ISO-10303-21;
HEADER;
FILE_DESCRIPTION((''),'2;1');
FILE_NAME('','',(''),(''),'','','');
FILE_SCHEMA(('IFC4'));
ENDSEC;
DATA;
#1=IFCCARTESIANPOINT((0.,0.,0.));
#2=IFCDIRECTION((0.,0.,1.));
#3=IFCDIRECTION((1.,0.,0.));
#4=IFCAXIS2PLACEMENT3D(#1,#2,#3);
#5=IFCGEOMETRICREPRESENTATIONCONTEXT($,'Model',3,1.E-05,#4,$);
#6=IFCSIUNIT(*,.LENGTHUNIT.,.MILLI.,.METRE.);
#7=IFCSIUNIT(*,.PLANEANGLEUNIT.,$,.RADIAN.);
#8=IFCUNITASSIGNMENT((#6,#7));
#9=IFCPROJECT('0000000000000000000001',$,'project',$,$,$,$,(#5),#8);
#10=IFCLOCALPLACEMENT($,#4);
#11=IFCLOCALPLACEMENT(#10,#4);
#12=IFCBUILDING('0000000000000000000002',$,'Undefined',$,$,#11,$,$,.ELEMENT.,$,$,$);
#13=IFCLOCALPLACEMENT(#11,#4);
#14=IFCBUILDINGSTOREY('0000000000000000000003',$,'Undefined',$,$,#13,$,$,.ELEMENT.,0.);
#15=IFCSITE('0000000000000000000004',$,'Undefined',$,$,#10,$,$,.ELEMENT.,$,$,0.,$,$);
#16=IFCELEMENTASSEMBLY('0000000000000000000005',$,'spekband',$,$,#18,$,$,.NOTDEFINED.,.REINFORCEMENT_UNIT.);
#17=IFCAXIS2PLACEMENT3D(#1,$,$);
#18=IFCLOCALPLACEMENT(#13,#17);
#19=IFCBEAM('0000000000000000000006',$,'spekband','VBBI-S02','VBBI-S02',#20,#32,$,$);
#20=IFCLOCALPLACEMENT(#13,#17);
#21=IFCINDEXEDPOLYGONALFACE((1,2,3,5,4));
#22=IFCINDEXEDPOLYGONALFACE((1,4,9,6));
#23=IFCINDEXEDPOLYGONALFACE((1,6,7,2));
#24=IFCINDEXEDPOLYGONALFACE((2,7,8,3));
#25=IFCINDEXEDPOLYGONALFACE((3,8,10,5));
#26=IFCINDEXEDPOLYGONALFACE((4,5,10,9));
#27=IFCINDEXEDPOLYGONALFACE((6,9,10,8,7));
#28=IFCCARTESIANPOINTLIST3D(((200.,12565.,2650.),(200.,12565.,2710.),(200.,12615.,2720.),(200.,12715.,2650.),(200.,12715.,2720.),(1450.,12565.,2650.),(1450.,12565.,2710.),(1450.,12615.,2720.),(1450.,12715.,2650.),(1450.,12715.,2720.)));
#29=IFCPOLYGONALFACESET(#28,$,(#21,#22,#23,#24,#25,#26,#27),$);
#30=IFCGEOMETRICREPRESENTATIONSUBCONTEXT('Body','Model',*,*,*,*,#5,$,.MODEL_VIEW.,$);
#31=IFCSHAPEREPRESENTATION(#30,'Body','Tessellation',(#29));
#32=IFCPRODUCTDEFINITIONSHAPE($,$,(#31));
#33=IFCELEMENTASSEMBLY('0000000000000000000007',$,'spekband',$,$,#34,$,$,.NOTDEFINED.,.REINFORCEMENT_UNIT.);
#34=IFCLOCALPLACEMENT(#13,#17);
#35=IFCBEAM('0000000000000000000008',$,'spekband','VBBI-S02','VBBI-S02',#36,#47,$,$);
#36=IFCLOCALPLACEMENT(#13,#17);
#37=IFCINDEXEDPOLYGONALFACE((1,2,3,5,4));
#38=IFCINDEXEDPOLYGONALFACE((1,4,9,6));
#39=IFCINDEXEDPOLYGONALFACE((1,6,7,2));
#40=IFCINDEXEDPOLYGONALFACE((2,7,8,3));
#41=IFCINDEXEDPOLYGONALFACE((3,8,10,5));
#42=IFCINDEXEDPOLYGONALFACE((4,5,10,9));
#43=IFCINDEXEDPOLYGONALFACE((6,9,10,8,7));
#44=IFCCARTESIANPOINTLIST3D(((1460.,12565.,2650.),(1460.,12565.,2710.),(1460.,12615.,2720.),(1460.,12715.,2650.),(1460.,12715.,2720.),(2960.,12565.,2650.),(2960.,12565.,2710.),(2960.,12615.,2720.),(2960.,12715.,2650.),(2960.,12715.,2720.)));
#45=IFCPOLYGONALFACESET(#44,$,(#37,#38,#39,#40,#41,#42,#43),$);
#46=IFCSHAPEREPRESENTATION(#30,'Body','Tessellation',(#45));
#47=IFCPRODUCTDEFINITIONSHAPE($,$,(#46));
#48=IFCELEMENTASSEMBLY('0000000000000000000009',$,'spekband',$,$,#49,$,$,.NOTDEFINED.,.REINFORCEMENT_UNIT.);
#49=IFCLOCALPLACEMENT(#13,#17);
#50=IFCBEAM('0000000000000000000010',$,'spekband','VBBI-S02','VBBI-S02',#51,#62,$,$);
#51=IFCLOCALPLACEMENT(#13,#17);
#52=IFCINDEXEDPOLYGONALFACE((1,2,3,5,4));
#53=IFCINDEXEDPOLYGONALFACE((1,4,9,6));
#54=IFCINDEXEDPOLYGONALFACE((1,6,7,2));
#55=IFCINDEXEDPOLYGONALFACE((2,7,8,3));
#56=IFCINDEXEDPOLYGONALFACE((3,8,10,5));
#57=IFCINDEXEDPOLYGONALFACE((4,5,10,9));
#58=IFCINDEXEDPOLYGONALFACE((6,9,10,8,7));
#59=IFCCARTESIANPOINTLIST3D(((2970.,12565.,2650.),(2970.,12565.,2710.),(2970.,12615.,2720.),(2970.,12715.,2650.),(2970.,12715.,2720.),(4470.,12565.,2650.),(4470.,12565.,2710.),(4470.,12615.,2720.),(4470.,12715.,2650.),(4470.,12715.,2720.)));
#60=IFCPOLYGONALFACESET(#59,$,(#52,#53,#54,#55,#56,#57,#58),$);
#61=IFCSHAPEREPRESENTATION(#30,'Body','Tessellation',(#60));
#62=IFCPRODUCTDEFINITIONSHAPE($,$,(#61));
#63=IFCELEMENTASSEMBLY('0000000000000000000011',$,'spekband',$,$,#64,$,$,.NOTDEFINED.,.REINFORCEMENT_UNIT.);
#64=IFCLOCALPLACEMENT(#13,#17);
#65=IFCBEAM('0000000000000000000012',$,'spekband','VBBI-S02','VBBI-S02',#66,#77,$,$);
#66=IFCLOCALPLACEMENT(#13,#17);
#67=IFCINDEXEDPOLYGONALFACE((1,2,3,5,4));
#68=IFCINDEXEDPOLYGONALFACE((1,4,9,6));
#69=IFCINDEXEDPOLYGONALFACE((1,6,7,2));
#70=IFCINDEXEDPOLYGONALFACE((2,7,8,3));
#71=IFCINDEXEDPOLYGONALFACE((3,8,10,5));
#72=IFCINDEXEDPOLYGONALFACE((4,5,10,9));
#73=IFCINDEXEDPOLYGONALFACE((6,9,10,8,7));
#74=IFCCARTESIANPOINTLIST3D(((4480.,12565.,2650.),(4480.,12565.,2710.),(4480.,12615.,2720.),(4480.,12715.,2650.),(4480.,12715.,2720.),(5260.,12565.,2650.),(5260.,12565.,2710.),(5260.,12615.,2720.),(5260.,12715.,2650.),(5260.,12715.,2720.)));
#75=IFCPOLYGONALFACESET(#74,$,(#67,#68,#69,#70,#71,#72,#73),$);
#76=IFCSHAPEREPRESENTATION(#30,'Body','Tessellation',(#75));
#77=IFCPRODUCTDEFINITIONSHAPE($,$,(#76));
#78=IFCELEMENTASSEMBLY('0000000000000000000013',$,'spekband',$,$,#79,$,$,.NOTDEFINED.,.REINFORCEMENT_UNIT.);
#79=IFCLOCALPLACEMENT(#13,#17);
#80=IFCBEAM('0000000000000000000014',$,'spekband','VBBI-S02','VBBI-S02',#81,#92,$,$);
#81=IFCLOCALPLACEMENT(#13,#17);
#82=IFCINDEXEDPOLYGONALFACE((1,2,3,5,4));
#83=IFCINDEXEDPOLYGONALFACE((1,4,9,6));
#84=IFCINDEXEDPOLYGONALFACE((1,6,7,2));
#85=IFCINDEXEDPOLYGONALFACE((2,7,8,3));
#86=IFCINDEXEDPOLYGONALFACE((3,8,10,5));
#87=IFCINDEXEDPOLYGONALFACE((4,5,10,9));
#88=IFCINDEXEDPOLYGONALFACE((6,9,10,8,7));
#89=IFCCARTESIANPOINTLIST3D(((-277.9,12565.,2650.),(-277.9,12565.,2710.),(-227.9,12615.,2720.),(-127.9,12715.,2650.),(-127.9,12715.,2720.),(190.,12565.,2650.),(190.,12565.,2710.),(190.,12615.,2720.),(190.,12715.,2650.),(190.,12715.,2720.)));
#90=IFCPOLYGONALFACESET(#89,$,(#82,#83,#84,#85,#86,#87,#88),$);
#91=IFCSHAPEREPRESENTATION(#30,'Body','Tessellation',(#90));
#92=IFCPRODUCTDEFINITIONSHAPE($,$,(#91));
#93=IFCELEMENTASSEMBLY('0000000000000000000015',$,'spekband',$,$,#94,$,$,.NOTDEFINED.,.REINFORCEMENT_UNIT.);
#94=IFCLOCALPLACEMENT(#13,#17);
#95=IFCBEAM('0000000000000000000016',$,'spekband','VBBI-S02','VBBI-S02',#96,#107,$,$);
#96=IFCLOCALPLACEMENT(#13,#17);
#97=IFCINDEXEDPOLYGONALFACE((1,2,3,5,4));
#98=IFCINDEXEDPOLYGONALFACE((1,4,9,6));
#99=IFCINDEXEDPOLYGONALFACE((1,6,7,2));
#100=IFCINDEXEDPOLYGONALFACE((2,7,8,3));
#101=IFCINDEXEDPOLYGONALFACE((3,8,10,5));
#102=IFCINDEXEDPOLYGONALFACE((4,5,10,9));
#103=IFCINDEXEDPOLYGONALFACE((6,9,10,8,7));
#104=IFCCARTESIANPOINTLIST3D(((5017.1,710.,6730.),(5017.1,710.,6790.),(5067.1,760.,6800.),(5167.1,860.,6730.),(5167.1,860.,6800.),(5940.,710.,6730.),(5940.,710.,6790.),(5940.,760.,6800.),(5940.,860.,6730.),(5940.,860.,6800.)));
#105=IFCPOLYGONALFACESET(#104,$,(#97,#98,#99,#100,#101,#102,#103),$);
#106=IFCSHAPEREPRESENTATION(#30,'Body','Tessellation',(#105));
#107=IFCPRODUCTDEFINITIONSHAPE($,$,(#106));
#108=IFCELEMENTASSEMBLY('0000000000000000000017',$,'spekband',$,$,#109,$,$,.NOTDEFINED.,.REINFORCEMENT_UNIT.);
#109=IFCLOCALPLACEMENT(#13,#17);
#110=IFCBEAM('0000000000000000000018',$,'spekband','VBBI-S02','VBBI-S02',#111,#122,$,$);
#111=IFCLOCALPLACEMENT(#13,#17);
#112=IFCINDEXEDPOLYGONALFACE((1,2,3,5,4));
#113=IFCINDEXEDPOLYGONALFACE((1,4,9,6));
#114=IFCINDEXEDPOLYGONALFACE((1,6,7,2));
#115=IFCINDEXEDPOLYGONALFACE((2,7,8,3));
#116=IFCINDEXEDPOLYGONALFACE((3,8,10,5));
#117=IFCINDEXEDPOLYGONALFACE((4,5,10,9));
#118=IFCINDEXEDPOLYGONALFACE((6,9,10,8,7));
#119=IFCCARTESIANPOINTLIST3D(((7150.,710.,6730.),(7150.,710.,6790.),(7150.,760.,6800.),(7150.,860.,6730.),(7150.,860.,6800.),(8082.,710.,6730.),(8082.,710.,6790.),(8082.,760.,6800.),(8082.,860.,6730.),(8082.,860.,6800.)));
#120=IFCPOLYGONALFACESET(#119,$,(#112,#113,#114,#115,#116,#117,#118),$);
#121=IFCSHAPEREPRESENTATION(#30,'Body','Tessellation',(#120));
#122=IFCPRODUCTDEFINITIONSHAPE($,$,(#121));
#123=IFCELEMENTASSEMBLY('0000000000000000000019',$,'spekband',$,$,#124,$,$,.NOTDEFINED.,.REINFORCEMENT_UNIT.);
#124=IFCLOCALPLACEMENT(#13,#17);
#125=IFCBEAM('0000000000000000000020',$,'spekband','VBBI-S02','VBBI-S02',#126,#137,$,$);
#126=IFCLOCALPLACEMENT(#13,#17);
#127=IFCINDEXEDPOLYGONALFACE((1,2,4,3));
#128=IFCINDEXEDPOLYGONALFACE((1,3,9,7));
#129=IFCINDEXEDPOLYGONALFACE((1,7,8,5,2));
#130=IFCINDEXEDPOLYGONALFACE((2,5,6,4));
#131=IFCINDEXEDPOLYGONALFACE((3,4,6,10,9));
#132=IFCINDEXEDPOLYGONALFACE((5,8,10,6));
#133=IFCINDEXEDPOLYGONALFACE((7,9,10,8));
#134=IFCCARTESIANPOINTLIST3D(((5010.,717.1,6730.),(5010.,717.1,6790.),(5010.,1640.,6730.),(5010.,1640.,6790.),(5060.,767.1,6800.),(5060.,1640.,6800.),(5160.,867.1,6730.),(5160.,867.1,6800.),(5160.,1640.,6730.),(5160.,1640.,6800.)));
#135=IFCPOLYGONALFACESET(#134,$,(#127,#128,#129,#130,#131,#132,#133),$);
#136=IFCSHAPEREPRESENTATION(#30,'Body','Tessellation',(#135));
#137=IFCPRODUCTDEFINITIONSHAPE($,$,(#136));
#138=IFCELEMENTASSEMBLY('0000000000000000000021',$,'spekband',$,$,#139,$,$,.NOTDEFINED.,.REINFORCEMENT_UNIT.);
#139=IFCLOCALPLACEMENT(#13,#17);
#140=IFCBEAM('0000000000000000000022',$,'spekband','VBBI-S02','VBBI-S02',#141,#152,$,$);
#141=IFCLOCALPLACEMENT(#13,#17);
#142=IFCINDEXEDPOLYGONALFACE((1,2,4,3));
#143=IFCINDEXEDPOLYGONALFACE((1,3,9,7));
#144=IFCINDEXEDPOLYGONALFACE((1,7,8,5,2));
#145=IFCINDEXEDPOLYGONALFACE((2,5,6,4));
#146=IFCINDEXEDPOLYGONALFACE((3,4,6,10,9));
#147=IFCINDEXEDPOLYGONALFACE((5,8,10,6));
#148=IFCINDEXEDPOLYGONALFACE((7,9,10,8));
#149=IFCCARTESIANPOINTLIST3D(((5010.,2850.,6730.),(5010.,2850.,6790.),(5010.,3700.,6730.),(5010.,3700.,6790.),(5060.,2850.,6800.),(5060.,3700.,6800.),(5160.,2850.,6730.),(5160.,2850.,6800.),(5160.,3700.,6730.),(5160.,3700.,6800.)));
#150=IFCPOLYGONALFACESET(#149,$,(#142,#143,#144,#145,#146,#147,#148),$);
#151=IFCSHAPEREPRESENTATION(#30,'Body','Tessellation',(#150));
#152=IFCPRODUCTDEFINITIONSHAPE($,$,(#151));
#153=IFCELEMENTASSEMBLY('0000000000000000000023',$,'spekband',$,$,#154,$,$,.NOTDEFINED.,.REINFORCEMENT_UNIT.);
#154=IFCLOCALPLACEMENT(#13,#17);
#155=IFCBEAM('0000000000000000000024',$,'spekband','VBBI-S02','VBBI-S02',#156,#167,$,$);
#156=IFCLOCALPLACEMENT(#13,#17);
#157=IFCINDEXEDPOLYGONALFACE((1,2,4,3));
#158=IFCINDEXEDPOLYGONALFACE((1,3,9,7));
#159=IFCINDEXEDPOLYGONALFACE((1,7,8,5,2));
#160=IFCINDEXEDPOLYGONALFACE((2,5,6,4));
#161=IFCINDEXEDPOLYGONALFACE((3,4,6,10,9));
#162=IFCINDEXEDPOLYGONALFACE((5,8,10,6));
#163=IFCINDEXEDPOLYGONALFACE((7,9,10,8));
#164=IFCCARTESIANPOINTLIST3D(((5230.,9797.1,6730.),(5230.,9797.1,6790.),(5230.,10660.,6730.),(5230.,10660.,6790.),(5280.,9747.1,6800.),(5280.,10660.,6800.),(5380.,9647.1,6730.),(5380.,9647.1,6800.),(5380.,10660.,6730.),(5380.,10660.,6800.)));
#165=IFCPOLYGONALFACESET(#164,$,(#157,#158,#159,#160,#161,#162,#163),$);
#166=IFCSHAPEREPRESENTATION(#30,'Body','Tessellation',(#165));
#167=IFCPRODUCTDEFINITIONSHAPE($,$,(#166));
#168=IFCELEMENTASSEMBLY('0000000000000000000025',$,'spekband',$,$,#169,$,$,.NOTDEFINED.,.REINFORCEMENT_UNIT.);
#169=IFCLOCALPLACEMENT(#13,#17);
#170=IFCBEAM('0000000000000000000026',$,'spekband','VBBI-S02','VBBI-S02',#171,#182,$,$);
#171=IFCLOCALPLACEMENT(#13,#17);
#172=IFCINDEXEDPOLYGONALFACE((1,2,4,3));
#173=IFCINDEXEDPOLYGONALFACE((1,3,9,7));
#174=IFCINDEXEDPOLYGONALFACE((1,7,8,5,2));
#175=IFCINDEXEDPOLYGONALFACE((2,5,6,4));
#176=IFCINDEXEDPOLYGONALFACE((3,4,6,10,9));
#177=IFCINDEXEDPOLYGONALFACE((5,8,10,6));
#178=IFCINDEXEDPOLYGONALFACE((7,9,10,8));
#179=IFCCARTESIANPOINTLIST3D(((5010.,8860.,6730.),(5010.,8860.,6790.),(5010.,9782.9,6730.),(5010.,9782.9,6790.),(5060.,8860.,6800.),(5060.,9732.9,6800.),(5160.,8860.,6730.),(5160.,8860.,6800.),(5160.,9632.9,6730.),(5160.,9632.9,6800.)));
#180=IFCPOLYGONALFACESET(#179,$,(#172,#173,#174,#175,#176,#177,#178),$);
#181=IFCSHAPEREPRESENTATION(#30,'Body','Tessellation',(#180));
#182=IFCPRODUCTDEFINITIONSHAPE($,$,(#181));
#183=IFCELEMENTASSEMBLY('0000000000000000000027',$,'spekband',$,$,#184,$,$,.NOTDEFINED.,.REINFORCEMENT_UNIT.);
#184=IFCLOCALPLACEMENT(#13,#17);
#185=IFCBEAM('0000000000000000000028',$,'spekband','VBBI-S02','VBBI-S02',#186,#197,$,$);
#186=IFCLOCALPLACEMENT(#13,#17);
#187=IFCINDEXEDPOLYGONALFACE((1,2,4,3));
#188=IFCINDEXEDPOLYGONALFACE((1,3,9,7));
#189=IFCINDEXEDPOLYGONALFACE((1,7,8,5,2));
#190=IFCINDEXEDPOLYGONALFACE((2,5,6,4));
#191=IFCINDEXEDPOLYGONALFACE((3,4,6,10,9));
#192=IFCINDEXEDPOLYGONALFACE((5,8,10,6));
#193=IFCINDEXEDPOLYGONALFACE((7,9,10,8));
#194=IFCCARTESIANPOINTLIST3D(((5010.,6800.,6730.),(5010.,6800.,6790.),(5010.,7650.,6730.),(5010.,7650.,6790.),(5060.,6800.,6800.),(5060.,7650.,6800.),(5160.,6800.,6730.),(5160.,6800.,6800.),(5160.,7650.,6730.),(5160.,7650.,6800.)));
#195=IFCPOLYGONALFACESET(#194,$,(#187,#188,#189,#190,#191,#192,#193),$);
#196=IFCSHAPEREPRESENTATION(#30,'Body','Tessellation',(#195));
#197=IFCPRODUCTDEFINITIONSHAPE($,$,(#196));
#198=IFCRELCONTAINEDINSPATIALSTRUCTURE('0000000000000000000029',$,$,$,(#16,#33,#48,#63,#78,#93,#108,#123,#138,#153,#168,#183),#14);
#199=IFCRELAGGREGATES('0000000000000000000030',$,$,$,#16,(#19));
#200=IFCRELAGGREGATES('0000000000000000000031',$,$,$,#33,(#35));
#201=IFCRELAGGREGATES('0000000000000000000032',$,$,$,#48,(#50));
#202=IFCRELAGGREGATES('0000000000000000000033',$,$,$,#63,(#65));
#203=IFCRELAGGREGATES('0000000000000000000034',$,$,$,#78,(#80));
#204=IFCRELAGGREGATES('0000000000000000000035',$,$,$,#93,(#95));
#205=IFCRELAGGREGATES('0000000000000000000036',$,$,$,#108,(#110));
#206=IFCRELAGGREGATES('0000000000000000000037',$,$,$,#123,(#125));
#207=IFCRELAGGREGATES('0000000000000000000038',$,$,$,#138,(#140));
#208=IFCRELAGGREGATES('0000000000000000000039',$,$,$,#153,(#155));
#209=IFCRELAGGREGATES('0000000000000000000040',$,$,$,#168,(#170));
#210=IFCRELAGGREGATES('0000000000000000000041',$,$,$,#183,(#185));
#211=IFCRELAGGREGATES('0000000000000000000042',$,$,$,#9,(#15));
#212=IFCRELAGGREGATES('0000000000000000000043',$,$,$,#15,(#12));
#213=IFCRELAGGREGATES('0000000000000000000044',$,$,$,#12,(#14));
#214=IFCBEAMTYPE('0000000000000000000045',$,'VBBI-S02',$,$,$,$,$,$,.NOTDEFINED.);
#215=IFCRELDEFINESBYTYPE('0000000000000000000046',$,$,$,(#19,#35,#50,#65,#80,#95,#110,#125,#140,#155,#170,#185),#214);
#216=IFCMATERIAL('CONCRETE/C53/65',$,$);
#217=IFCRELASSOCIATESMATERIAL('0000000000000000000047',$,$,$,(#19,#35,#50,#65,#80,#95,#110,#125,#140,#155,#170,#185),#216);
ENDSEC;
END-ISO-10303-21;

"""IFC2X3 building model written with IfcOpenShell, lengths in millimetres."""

from ifc_helpers import new_model, si_unit, frame, origin_with_axes, place, context, subcontext, project, spatial, polyline, outline, extrude, clip, halfspace, material, type_object, element, aggregate, save


model = new_model("IFC2X3")

# Units and contexts
model_context = context("Model", 3, precision=1e-05, world=origin_with_axes())
body_context = subcontext(model_context, "Body", "Model", "MODEL_VIEW")
ifc_project = project(units=[si_unit("LENGTHUNIT", "METRE", prefix="MILLI"), si_unit("PLANEANGLEUNIT", "RADIAN")], contexts=[model_context])

# Site, building, storey
site_placement = place(None, origin_with_axes())
site = spatial("IfcSite", under=ifc_project, at=site_placement, Name="Undefined", CompositionType="ELEMENT", RefElevation=0.0)
building_placement = place(site_placement, origin_with_axes())
building = spatial("IfcBuilding", under=site, at=building_placement, Name="Undefined", CompositionType="ELEMENT")
storey_placement = place(building_placement, origin_with_axes())
storey = spatial("IfcBuildingStorey", under=building, at=storey_placement, Name="Undefined", CompositionType="ELEMENT", Elevation=0.0)

# Element assemblies, beams
assembly_1_placement = place(storey_placement, origin_with_axes())
assembly_1 = element("IfcElementAssembly", 1, at=assembly_1_placement, inside=storey, Name="spekband", AssemblyPlace="NOTDEFINED", PredefinedType="REINFORCEMENT_UNIT")
ifc_material = material(Name="CONCRETE/C53/65")
beam_type_1 = type_object("IfcBeamType", Name="VBBI-S02", PredefinedType="NOTDEFINED")
beam_1_placement = place(assembly_1_placement, frame((200.0, 12640.0, 2685.0), z_axis=(0.0, -1.0, 0.0), x_axis=(1.0, 0.0, 0.0)))
beam_1 = element("IfcBeam", 2, at=beam_1_placement, type_object=beam_type_1, material=ifc_material, Name="spekband", Description="VBBI-S02", ObjectType="VBBI-S02", context=body_context, shape_type="SweptSolid", body=[
    extrude(outline(polyline([(35.0, -75.0), (-35.0, -75.0), (-35.0, 25.0), (-25.0, 75.0), (35.0, 75.0), (35.0, -75.0)])), frame((1250.0, 0.0, 0.0), z_axis=(-1.0, 0.0, 0.0), x_axis=(0.0, -1.0, 0.0)), (0.0, 0.0, 1.0), 1250.0),
])
aggregate(assembly_1, [beam_1])
assembly_2_placement = place(storey_placement, origin_with_axes())
assembly_2 = element("IfcElementAssembly", 3, at=assembly_2_placement, inside=storey, Name="spekband", AssemblyPlace="NOTDEFINED", PredefinedType="REINFORCEMENT_UNIT")
beam_2_placement = place(assembly_2_placement, frame((1460.0, 12640.0, 2685.0), z_axis=(0.0, -1.0, 0.0), x_axis=(1.0, 0.0, 0.0)))
beam_2 = element("IfcBeam", 4, at=beam_2_placement, type_object=beam_type_1, material=ifc_material, Name="spekband", Description="VBBI-S02", ObjectType="VBBI-S02", context=body_context, shape_type="SweptSolid", body=[
    extrude(outline(polyline([(35.0, -75.0), (-35.0, -75.0), (-35.0, 25.0), (-25.0, 75.0), (35.0, 75.0), (35.0, -75.0)])), frame((1500.0, 0.0, 0.0), z_axis=(-1.0, 0.0, 0.0), x_axis=(0.0, -1.0, 0.0)), (0.0, 0.0, 1.0), 1500.0),
])
aggregate(assembly_2, [beam_2])
assembly_3_placement = place(storey_placement, origin_with_axes())
assembly_3 = element("IfcElementAssembly", 5, at=assembly_3_placement, inside=storey, Name="spekband", AssemblyPlace="NOTDEFINED", PredefinedType="REINFORCEMENT_UNIT")
beam_3_placement = place(assembly_3_placement, frame((2970.0, 12640.0, 2685.0), z_axis=(0.0, -1.0, 0.0), x_axis=(1.0, 0.0, 0.0)))
beam_3 = element("IfcBeam", 6, at=beam_3_placement, type_object=beam_type_1, material=ifc_material, Name="spekband", Description="VBBI-S02", ObjectType="VBBI-S02", context=body_context, shape_type="SweptSolid", body=[
    extrude(outline(polyline([(35.0, -75.0), (-35.0, -75.0), (-35.0, 25.0), (-25.0, 75.0), (35.0, 75.0), (35.0, -75.0)])), frame((1500.0, 0.0, 0.0), z_axis=(-1.0, 0.0, 0.0), x_axis=(0.0, -1.0, 0.0)), (0.0, 0.0, 1.0), 1500.0),
])
aggregate(assembly_3, [beam_3])
assembly_4_placement = place(storey_placement, origin_with_axes())
assembly_4 = element("IfcElementAssembly", 7, at=assembly_4_placement, inside=storey, Name="spekband", AssemblyPlace="NOTDEFINED", PredefinedType="REINFORCEMENT_UNIT")
beam_4_placement = place(assembly_4_placement, frame((4480.0, 12640.0, 2685.0), z_axis=(0.0, -1.0, 0.0), x_axis=(1.0, 0.0, 0.0)))
beam_4 = element("IfcBeam", 8, at=beam_4_placement, type_object=beam_type_1, material=ifc_material, Name="spekband", Description="VBBI-S02", ObjectType="VBBI-S02", context=body_context, shape_type="SweptSolid", body=[
    extrude(outline(polyline([(35.0, -75.0), (-35.0, -75.0), (-35.0, 25.0), (-25.0, 75.0), (35.0, 75.0), (35.0, -75.0)])), frame((780.0, 0.0, 0.0), z_axis=(-1.0, 0.0, 0.0), x_axis=(0.0, -1.0, 0.0)), (0.0, 0.0, 1.0), 780.0),
])
aggregate(assembly_4, [beam_4])
assembly_5_placement = place(storey_placement, origin_with_axes())
assembly_5 = element("IfcElementAssembly", 9, at=assembly_5_placement, inside=storey, Name="spekband", AssemblyPlace="NOTDEFINED", PredefinedType="REINFORCEMENT_UNIT")
beam_5_placement = place(assembly_5_placement, frame((-285.0, 12640.0, 2685.0), z_axis=(0.0, -1.0, 0.0), x_axis=(1.0, 0.0, 0.0)))
beam_5 = element("IfcBeam", 10, at=beam_5_placement, type_object=beam_type_1, material=ifc_material, Name="spekband", Description="VBBI-S02", ObjectType="VBBI-S02", context=body_context, shape_type="Clipping", body=[
    clip(extrude(outline(polyline([(35.0, -75.0), (-35.0, -75.0), (-35.0, 25.0), (-25.0, 75.0), (35.0, 75.0), (35.0, -75.0)])), frame((475.0, 0.0, 0.0), z_axis=(-1.0, 0.0, 0.0), x_axis=(0.0, -1.0, 0.0)), (0.0, 0.0, 1.0), 468.7), halfspace(frame((3.5, 0.0, 78.5), z_axis=(0.707107, 0.0, 0.707107), x_axis=(0.0, 1.0, 0.0)), True)),
])
aggregate(assembly_5, [beam_5])
assembly_6_placement = place(storey_placement, origin_with_axes())
assembly_6 = element("IfcElementAssembly", 11, at=assembly_6_placement, inside=storey, Name="spekband", AssemblyPlace="NOTDEFINED", PredefinedType="REINFORCEMENT_UNIT")
beam_6_placement = place(assembly_6_placement, frame((5010.0, 785.0, 6765.0), z_axis=(0.0, -1.0, 0.0), x_axis=(1.0, 0.0, 0.0)))
beam_6 = element("IfcBeam", 12, at=beam_6_placement, type_object=beam_type_1, material=ifc_material, Name="spekband", Description="VBBI-S02", ObjectType="VBBI-S02", context=body_context, shape_type="Clipping", body=[
    clip(extrude(outline(polyline([(35.0, -75.0), (-35.0, -75.0), (-35.0, 25.0), (-25.0, 75.0), (35.0, 75.0), (35.0, -75.0)])), frame((930.0, 0.0, 0.0), z_axis=(-1.0, 0.0, 0.0), x_axis=(0.0, -1.0, 0.0)), (0.0, 0.0, 1.0), 923.7), halfspace(frame((3.5, 0.0, 78.5), z_axis=(0.707107, 0.0, 0.707107), x_axis=(0.0, 1.0, 0.0)), True)),
])
aggregate(assembly_6, [beam_6])
assembly_7_placement = place(storey_placement, origin_with_axes())
assembly_7 = element("IfcElementAssembly", 13, at=assembly_7_placement, inside=storey, Name="spekband", AssemblyPlace="NOTDEFINED", PredefinedType="REINFORCEMENT_UNIT")
beam_7_placement = place(assembly_7_placement, frame((7150.0, 785.0, 6765.0), z_axis=(0.0, -1.0, 0.0), x_axis=(1.0, 0.0, 0.0)))
beam_7 = element("IfcBeam", 14, at=beam_7_placement, type_object=beam_type_1, material=ifc_material, Name="spekband", Description="VBBI-S02", ObjectType="VBBI-S02", context=body_context, shape_type="SweptSolid", body=[
    extrude(outline(polyline([(35.0, -75.0), (-35.0, -75.0), (-35.0, 25.0), (-25.0, 75.0), (35.0, 75.0), (35.0, -75.0)])), frame((932.0, 0.0, 0.0), z_axis=(-1.0, 0.0, 0.0), x_axis=(0.0, -1.0, 0.0)), (0.0, 0.0, 1.0), 932.0),
])
aggregate(assembly_7, [beam_7])
assembly_8_placement = place(storey_placement, origin_with_axes())
assembly_8 = element("IfcElementAssembly", 15, at=assembly_8_placement, inside=storey, Name="spekband", AssemblyPlace="NOTDEFINED", PredefinedType="REINFORCEMENT_UNIT")
beam_8_placement = place(assembly_8_placement, frame((5085.0, 1640.0, 6765.0), z_axis=(-1.0, 0.0, 0.0), x_axis=(0.0, -1.0, 0.0)))
beam_8 = element("IfcBeam", 16, at=beam_8_placement, type_object=beam_type_1, material=ifc_material, Name="spekband", Description="VBBI-S02", ObjectType="VBBI-S02", context=body_context, shape_type="Clipping", body=[
    clip(extrude(outline(polyline([(35.0, -75.0), (-35.0, -75.0), (-35.0, 25.0), (-25.0, 75.0), (35.0, 75.0), (35.0, -75.0)])), frame((923.7, 0.0, 0.0), z_axis=(-1.0, 0.0, 0.0), x_axis=(0.0, -1.0, 0.0)), (0.0, 0.0, 1.0), 923.7), halfspace(frame((926.5, 0.0, 78.5), z_axis=(0.707107, 0.0, -0.707107), x_axis=(0.0, 1.0, 0.0)), False)),
])
aggregate(assembly_8, [beam_8])
assembly_9_placement = place(storey_placement, origin_with_axes())
assembly_9 = element("IfcElementAssembly", 17, at=assembly_9_placement, inside=storey, Name="spekband", AssemblyPlace="NOTDEFINED", PredefinedType="REINFORCEMENT_UNIT")
beam_9_placement = place(assembly_9_placement, frame((5085.0, 3700.0, 6765.0), z_axis=(-1.0, 0.0, 0.0), x_axis=(0.0, -1.0, 0.0)))
beam_9 = element("IfcBeam", 18, at=beam_9_placement, type_object=beam_type_1, material=ifc_material, Name="spekband", Description="VBBI-S02", ObjectType="VBBI-S02", context=body_context, shape_type="SweptSolid", body=[
    extrude(outline(polyline([(35.0, -75.0), (-35.0, -75.0), (-35.0, 25.0), (-25.0, 75.0), (35.0, 75.0), (35.0, -75.0)])), frame((850.0, 0.0, 0.0), z_axis=(-1.0, 0.0, 0.0), x_axis=(0.0, -1.0, 0.0)), (0.0, 0.0, 1.0), 850.0),
])
aggregate(assembly_9, [beam_9])
assembly_10_placement = place(storey_placement, origin_with_axes())
assembly_10 = element("IfcElementAssembly", 19, at=assembly_10_placement, inside=storey, Name="spekband", AssemblyPlace="NOTDEFINED", PredefinedType="REINFORCEMENT_UNIT")
beam_10_placement = place(assembly_10_placement, frame((5305.0, 10660.0, 6765.0), z_axis=(-1.0, 0.0, 0.0), x_axis=(0.0, -1.0, 0.0)))
beam_10 = element("IfcBeam", 20, at=beam_10_placement, type_object=beam_type_1, material=ifc_material, Name="spekband", Description="VBBI-S02", ObjectType="VBBI-S02", context=body_context, shape_type="Clipping", body=[
    clip(extrude(outline(polyline([(35.0, -75.0), (-35.0, -75.0), (-35.0, 25.0), (-25.0, 75.0), (35.0, 75.0), (35.0, -75.0)])), frame((1013.7, 0.0, 0.0), z_axis=(-1.0, 0.0, 0.0), x_axis=(0.0, -1.0, 0.0)), (0.0, 0.0, 1.0), 1013.7), halfspace(frame((1016.5, 0.0, -78.5), z_axis=(-0.707107, 0.0, -0.707107), x_axis=(0.0, 1.0, 0.0)), True)),
])
aggregate(assembly_10, [beam_10])
assembly_11_placement = place(storey_placement, origin_with_axes())
assembly_11 = element("IfcElementAssembly", 21, at=assembly_11_placement, inside=storey, Name="spekband", AssemblyPlace="NOTDEFINED", PredefinedType="REINFORCEMENT_UNIT")
beam_11_placement = place(assembly_11_placement, frame((5085.0, 9790.0, 6765.0), z_axis=(-1.0, 0.0, 0.0), x_axis=(0.0, -1.0, 0.0)))
beam_11 = element("IfcBeam", 22, at=beam_11_placement, type_object=beam_type_1, material=ifc_material, Name="spekband", Description="VBBI-S02", ObjectType="VBBI-S02", context=body_context, shape_type="Clipping", body=[
    clip(extrude(outline(polyline([(35.0, -75.0), (-35.0, -75.0), (-35.0, 25.0), (-25.0, 75.0), (35.0, 75.0), (35.0, -75.0)])), frame((930.0, 0.0, 0.0), z_axis=(-1.0, 0.0, 0.0), x_axis=(0.0, -1.0, 0.0)), (0.0, 0.0, 1.0), 923.7), halfspace(frame((3.5, 0.0, 78.5), z_axis=(0.707107, 0.0, 0.707107), x_axis=(0.0, 1.0, 0.0)), True)),
])
aggregate(assembly_11, [beam_11])
assembly_12_placement = place(storey_placement, origin_with_axes())
assembly_12 = element("IfcElementAssembly", 23, at=assembly_12_placement, inside=storey, Name="spekband", AssemblyPlace="NOTDEFINED", PredefinedType="REINFORCEMENT_UNIT")
beam_12_placement = place(assembly_12_placement, frame((5085.0, 7650.0, 6765.0), z_axis=(-1.0, 0.0, 0.0), x_axis=(0.0, -1.0, 0.0)))
beam_12 = element("IfcBeam", 24, at=beam_12_placement, type_object=beam_type_1, material=ifc_material, Name="spekband", Description="VBBI-S02", ObjectType="VBBI-S02", context=body_context, shape_type="SweptSolid", body=[
    extrude(outline(polyline([(35.0, -75.0), (-35.0, -75.0), (-35.0, 25.0), (-25.0, 75.0), (35.0, 75.0), (35.0, -75.0)])), frame((850.0, 0.0, 0.0), z_axis=(-1.0, 0.0, 0.0), x_axis=(0.0, -1.0, 0.0)), (0.0, 0.0, 1.0), 850.0),
])
aggregate(assembly_12, [beam_12])

save(model, "model.ifc")
